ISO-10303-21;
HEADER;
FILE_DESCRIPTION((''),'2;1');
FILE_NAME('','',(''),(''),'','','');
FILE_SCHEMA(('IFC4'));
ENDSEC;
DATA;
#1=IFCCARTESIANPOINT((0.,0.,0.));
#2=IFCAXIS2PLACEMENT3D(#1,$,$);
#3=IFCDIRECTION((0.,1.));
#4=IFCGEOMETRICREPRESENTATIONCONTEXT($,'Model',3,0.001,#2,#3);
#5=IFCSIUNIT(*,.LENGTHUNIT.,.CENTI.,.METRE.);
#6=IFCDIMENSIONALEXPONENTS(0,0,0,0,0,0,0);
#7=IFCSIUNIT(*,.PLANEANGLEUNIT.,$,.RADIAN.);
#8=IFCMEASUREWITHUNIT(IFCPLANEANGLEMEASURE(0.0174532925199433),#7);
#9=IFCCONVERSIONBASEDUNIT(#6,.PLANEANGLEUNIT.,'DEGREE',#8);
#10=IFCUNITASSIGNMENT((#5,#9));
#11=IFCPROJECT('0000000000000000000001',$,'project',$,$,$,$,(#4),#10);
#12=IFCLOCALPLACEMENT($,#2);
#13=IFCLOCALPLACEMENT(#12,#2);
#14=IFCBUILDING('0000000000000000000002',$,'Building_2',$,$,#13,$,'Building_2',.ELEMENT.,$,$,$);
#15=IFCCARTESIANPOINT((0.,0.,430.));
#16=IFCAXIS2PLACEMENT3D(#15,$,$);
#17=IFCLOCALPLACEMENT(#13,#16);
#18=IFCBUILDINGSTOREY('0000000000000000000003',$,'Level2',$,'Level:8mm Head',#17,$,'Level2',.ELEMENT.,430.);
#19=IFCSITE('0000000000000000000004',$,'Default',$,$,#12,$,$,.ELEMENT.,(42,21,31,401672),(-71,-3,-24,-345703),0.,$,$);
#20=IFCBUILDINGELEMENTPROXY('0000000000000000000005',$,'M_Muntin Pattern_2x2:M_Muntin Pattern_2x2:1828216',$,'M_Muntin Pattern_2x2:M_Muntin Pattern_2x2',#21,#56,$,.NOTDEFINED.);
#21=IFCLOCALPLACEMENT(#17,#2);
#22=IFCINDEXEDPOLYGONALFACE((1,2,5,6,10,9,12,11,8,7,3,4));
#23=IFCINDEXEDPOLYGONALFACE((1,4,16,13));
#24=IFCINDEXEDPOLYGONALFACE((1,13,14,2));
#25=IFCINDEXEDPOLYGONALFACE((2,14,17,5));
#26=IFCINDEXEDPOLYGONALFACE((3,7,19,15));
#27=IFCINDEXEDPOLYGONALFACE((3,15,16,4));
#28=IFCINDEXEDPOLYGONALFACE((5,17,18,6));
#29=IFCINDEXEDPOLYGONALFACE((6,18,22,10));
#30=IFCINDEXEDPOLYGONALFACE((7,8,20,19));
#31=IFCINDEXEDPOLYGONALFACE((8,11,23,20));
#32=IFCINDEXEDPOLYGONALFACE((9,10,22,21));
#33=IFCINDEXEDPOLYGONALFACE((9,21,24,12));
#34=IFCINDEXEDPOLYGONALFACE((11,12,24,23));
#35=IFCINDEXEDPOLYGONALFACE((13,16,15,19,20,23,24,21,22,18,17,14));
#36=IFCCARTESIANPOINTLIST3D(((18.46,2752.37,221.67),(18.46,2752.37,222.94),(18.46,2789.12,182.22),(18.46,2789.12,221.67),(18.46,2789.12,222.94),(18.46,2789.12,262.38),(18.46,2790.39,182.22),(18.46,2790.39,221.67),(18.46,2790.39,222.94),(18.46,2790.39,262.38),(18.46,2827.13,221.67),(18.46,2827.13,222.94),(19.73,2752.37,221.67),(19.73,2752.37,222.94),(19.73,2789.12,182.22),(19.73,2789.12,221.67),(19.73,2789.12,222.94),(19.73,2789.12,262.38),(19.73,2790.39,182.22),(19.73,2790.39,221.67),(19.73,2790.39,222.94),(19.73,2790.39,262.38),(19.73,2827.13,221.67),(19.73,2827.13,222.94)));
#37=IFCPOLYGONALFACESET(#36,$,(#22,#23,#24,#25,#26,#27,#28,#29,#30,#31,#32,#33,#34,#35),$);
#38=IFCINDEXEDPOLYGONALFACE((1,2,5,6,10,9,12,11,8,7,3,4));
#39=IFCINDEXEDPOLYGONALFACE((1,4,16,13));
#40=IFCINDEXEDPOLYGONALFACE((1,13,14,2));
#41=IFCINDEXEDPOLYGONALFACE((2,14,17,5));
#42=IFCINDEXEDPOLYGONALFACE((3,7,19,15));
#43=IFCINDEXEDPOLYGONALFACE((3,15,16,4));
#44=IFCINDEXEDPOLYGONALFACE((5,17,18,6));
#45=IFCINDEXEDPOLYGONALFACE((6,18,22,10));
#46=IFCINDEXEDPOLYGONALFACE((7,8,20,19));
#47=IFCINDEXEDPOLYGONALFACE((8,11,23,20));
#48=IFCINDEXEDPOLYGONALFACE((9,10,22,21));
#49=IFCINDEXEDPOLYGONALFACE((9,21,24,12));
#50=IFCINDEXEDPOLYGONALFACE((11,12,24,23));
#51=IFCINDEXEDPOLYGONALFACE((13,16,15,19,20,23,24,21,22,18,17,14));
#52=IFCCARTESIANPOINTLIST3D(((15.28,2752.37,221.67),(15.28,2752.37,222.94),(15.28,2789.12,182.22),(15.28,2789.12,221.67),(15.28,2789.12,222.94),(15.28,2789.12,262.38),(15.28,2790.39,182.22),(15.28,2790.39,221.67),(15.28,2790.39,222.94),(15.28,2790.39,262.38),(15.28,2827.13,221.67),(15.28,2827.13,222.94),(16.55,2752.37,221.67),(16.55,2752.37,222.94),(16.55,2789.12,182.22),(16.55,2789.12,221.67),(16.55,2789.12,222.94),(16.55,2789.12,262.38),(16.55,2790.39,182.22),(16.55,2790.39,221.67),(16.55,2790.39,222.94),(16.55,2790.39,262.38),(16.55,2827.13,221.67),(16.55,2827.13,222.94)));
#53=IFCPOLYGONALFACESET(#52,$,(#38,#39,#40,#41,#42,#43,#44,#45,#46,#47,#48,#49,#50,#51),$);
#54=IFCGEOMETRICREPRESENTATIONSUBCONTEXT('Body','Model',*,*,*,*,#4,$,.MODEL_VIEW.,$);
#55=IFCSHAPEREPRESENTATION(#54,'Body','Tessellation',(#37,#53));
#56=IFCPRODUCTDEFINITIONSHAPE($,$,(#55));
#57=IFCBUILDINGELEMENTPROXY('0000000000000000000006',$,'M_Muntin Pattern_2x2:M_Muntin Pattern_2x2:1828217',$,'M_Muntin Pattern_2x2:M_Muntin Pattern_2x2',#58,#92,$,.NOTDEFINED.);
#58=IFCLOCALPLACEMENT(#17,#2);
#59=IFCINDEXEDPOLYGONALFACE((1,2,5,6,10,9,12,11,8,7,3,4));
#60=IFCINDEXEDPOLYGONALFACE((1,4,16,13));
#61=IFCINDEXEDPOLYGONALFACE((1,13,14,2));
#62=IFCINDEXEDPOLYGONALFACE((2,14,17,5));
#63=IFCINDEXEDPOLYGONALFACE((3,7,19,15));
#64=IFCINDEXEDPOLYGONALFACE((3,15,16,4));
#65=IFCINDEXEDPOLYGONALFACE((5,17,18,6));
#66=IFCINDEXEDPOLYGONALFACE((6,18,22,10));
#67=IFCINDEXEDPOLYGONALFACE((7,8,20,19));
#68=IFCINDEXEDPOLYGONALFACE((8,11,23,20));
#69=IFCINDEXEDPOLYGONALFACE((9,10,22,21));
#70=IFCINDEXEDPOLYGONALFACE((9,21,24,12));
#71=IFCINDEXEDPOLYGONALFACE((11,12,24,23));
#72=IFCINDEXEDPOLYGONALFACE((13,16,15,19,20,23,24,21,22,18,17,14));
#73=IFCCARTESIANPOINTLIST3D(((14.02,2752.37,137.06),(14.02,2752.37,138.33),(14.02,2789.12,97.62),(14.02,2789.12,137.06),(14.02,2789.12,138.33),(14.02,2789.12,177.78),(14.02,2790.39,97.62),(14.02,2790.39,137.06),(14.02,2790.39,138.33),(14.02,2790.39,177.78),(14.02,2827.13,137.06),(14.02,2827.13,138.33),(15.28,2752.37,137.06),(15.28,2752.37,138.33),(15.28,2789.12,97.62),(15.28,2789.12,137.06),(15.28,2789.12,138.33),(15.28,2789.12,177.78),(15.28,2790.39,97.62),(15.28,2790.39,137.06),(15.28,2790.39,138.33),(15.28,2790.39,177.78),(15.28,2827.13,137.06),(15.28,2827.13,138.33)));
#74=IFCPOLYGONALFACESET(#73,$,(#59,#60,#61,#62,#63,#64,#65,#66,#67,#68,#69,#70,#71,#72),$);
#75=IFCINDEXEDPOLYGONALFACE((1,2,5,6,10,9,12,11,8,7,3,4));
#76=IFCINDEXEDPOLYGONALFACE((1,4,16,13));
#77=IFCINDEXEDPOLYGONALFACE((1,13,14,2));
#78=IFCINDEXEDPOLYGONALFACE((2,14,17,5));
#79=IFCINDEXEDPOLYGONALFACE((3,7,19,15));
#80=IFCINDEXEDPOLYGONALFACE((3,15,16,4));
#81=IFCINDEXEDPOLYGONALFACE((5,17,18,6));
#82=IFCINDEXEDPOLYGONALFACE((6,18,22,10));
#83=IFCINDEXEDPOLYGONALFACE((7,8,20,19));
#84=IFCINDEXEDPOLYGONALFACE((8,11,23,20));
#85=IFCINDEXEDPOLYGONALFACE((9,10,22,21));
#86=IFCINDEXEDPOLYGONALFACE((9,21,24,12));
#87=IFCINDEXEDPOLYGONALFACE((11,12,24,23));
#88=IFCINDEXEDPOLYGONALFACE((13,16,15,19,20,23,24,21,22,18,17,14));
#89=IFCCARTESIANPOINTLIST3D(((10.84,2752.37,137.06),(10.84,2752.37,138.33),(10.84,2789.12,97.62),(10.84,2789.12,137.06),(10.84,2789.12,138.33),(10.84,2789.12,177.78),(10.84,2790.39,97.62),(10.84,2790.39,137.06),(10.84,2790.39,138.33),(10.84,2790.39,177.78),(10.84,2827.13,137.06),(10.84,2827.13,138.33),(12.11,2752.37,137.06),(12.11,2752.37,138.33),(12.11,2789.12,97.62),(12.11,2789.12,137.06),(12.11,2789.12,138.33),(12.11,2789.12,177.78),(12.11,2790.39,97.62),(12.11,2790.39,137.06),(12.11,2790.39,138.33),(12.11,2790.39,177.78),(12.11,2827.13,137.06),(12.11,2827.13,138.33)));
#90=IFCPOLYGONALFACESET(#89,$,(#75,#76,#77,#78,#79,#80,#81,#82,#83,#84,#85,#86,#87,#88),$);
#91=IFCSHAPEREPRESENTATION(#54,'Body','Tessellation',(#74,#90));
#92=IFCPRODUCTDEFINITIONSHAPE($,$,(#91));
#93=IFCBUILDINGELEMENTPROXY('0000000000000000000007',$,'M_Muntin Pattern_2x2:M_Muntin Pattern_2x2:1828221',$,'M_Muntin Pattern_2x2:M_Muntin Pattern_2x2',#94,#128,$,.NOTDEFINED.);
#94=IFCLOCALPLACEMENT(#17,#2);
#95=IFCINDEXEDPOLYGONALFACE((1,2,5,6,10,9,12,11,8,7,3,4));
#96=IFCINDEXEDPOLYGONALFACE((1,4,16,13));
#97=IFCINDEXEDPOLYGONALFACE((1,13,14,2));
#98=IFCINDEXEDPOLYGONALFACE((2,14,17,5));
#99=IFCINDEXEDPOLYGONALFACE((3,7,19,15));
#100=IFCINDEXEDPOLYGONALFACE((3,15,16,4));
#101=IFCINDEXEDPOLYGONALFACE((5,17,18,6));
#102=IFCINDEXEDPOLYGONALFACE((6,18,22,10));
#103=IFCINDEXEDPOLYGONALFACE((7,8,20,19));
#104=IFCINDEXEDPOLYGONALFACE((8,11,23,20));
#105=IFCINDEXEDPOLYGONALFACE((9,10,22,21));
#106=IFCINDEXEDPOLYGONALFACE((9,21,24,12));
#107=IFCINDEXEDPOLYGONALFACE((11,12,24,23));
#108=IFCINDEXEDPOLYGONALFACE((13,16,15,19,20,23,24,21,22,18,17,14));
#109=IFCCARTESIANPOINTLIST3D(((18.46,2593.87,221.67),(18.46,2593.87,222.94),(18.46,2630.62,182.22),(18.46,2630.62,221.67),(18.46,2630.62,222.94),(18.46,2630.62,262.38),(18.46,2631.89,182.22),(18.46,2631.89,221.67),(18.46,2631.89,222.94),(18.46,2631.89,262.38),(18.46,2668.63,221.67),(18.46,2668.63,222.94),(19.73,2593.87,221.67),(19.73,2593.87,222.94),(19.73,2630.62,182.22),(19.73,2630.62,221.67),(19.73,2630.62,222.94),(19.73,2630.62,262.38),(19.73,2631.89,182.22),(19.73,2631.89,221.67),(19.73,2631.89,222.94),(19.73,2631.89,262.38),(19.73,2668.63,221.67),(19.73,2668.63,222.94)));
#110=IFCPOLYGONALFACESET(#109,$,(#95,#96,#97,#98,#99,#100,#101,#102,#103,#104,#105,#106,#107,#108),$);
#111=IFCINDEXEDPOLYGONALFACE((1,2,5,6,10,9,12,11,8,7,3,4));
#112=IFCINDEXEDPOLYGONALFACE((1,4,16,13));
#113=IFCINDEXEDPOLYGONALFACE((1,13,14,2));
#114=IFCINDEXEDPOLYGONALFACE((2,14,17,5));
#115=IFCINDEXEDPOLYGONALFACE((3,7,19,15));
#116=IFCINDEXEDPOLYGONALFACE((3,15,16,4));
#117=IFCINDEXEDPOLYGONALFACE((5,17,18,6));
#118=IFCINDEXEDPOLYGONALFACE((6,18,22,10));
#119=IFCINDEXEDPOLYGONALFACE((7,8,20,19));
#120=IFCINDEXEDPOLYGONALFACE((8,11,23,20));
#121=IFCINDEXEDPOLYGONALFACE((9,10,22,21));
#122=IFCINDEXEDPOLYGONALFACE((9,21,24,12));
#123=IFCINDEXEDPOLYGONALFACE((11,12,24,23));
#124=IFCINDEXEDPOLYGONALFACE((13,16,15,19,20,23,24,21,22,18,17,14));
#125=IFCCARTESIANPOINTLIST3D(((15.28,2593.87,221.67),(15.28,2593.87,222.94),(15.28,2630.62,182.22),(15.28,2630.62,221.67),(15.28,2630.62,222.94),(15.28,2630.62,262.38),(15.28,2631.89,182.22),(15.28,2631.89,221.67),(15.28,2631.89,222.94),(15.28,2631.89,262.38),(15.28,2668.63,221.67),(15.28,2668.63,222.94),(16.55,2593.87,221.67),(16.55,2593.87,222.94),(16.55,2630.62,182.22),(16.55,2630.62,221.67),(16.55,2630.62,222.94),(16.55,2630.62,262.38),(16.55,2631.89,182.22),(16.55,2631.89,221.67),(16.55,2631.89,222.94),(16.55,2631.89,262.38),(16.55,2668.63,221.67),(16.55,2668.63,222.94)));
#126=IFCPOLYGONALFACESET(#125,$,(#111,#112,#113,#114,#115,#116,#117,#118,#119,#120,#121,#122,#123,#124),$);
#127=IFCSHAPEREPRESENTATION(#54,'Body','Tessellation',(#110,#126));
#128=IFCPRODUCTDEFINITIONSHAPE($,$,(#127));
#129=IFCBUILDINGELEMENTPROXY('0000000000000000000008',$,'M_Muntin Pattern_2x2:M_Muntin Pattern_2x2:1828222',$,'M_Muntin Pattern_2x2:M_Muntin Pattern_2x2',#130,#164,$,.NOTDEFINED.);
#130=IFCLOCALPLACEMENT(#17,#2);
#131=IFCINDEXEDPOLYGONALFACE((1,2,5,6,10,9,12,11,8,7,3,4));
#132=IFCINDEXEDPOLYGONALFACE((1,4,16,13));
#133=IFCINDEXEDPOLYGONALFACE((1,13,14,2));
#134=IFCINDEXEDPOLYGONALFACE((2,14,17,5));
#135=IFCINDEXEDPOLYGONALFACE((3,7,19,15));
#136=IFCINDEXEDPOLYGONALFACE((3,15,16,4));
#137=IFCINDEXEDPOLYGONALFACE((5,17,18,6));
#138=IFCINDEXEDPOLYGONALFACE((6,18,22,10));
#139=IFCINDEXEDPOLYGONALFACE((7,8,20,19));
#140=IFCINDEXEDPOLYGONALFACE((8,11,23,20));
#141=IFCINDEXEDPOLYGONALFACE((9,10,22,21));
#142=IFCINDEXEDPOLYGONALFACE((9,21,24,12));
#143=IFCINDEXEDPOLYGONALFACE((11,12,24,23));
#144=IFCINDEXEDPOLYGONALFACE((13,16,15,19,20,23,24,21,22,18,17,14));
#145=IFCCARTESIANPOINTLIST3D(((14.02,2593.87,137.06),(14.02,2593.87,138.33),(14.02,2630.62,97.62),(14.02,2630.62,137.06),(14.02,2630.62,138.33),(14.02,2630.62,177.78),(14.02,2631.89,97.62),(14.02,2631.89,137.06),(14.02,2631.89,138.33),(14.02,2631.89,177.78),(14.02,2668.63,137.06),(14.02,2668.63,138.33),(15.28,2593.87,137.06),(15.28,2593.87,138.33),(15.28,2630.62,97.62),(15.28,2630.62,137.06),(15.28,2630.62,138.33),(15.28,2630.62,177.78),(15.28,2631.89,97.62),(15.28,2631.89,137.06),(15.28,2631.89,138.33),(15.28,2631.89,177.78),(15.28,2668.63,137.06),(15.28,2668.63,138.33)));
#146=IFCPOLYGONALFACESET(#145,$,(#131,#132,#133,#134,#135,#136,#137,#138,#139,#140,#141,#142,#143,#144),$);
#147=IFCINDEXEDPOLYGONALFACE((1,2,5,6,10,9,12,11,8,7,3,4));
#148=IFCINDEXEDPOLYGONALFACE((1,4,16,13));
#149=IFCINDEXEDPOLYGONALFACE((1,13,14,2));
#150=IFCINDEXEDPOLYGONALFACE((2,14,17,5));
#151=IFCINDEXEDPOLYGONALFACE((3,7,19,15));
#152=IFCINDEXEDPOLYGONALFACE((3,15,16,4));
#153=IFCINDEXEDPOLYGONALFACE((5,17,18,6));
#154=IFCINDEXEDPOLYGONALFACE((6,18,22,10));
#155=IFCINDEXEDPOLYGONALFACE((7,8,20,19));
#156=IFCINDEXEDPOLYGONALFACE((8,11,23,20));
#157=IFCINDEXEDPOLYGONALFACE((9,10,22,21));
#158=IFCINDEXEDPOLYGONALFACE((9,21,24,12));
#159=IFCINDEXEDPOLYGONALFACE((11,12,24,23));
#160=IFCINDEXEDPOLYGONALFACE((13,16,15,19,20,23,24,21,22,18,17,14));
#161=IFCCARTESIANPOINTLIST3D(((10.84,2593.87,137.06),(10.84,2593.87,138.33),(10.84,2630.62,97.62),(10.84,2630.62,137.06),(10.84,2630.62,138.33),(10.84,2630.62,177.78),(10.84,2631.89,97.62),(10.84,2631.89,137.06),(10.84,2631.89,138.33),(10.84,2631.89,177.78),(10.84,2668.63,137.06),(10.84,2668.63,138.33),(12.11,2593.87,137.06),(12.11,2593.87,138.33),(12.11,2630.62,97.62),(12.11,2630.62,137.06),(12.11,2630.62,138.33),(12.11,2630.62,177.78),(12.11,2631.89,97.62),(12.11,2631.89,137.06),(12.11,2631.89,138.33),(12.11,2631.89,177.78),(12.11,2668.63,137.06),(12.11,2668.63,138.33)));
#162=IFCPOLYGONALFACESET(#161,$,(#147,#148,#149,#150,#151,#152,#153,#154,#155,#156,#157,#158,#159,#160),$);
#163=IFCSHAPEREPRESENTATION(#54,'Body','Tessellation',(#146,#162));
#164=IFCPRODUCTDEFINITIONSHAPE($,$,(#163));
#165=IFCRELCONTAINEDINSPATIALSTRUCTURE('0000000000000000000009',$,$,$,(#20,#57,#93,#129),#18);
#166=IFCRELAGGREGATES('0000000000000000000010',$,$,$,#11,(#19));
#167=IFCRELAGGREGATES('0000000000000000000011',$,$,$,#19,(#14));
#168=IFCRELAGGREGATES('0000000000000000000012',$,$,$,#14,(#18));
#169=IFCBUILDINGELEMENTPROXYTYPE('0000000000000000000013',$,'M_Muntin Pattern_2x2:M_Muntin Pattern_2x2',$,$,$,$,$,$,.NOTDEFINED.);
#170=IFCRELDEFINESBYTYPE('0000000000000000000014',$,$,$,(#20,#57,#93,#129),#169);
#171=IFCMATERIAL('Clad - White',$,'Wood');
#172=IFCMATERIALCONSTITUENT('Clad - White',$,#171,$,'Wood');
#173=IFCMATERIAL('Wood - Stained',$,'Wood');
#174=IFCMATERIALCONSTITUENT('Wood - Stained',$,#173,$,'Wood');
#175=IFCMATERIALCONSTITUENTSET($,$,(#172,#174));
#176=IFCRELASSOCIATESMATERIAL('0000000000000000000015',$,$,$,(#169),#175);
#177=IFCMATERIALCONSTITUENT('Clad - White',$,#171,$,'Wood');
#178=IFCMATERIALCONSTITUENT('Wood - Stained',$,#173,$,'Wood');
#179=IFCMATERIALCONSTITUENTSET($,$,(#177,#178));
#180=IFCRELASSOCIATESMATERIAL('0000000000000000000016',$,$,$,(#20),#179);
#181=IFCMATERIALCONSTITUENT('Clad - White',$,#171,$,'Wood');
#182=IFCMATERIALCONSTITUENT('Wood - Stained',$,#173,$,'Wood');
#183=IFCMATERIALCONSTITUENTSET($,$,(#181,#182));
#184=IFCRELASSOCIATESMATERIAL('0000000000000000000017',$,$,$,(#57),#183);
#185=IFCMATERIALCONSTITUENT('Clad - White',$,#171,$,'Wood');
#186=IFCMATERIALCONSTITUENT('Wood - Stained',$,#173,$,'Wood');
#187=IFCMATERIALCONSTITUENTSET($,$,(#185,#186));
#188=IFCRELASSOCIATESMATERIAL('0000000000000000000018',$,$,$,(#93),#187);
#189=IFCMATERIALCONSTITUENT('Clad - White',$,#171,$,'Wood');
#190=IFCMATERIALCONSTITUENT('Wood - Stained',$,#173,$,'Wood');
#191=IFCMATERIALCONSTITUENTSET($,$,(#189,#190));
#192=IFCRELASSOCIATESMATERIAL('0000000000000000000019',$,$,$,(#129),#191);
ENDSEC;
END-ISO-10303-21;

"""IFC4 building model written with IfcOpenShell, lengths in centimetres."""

from ifc_helpers import new_model, entity, si_unit, converted_unit, direction, frame, origin, place, context, subcontext, project, spatial, indexed_curve, outline, extrude, source, transform, mapped, material, constituent, constituent_set, type_object, type_shapes, element, save


model = new_model("IFC4")

# Units and contexts
model_context = context("Model", 3, precision=0.001, world=origin(), true_north=direction((0.0, 1.0)))
body_context = subcontext(model_context, "Body", "Model", "MODEL_VIEW")
ifc_project = project(units=[si_unit("LENGTHUNIT", "METRE", prefix="CENTI"), converted_unit("PLANEANGLEUNIT", "DEGREE", entity("IfcPlaneAngleMeasure", 0.0174532925199433), si_unit("PLANEANGLEUNIT", "RADIAN"), dimensions=[0, 0, 0, 0, 0, 0, 0])], contexts=[model_context])

# Site, building, storey
site_placement = place(None, origin())
site = spatial("IfcSite", under=ifc_project, at=site_placement, Name="Default", CompositionType="ELEMENT", RefLatitude=(42, 21, 31, 401672), RefLongitude=(-71, -3, -24, -345703), RefElevation=0.0)
building_placement = place(site_placement, origin())
building = spatial("IfcBuilding", under=site, at=building_placement, Name="Building_2", LongName="Building_2", CompositionType="ELEMENT")
storey_placement = place(building_placement, frame((0.0, 0.0, 430.0)))
storey = spatial("IfcBuildingStorey", under=building, at=storey_placement, Name="Level2", ObjectType="Level:8mm Head", LongName="Level2", CompositionType="ELEMENT", Elevation=430.0)

# Shared definitions
ifc_material_1 = material(Name="Wood - Stained", Category="Wood")

# Building element proxies
ifc_material_2 = material(Name="Clad - White", Category="Wood")
ifc_constituent_1 = constituent(ifc_material_2, Name="Clad - White", Category="Wood")
ifc_constituent_2 = constituent(ifc_material_1, Name="Wood - Stained", Category="Wood")
ifc_constituent_set_1 = constituent_set(constituents=[ifc_constituent_1, ifc_constituent_2])
ifc_constituent_3 = constituent(ifc_material_2, Name="Clad - White", Category="Wood")
ifc_constituent_4 = constituent(ifc_material_1, Name="Wood - Stained", Category="Wood")
ifc_constituent_set_2 = constituent_set(constituents=[ifc_constituent_3, ifc_constituent_4])
building_element_proxy_type_1 = type_object("IfcBuildingElementProxyType", Name="M_Muntin Pattern_2x2:M_Muntin Pattern_2x2", PredefinedType="NOTDEFINED", material=ifc_constituent_set_2)
shared_shape_1 = source(origin(), body_context, "Body", "SweptSolid", [
    extrude(outline(indexed_curve([(0.64, -0.64), (40.08, -0.64), (40.08, 0.63), (0.64, 0.63), (0.64, 37.38), (-0.63, 37.38), (-0.63, 0.63), (-40.08, 0.63), (-40.08, -0.64), (-0.63, -0.64), (-0.63, -37.38), (0.64, -37.38), (0.64, -0.64)], self_intersect=False)), frame((0.0, 0.95, 40.08), z_axis=(0.0, 1.0, 0.0), x_axis=(0.0, 0.0, 1.0)), (0.0, 0.0, 1.0), 1.27),
    extrude(outline(indexed_curve([(0.64, -0.64), (40.08, -0.64), (40.08, 0.63), (0.64, 0.63), (0.64, 37.38), (-0.63, 37.38), (-0.63, 0.63), (-40.08, 0.63), (-40.08, -0.64), (-0.63, -0.64), (-0.63, -37.38), (0.64, -37.38), (0.64, -0.64)], self_intersect=False)), frame((0.0, -2.22, 40.08), z_axis=(0.0, 1.0, 0.0), x_axis=(0.0, 0.0, 1.0)), (0.0, 0.0, 1.0), 1.27),
])
type_shapes(building_element_proxy_type_1, [shared_shape_1])
proxy_1_placement = place(storey_placement, frame((17.51, 2789.75, 182.22), z_axis=(0.0, 0.0, 1.0), x_axis=(0.0, -1.0, 0.0)))
element("IfcBuildingElementProxy", 1, at=proxy_1_placement, inside=storey, type_object=building_element_proxy_type_1, material=ifc_constituent_set_1, Name="M_Muntin Pattern_2x2:M_Muntin Pattern_2x2:1828216", ObjectType="M_Muntin Pattern_2x2:M_Muntin Pattern_2x2", PredefinedType="NOTDEFINED", context=body_context, shape_type="MappedRepresentation", body=[
    mapped(shared_shape_1, transform((0.0, 0.0, 0.0), scale=1.0)),
])
ifc_constituent_5 = constituent(ifc_material_2, Name="Clad - White", Category="Wood")
ifc_constituent_6 = constituent(ifc_material_1, Name="Wood - Stained", Category="Wood")
ifc_constituent_set_3 = constituent_set(constituents=[ifc_constituent_5, ifc_constituent_6])
proxy_2_placement = place(storey_placement, frame((13.06, 2789.75, 97.62), z_axis=(0.0, 0.0, 1.0), x_axis=(0.0, -1.0, 0.0)))
element("IfcBuildingElementProxy", 2, at=proxy_2_placement, inside=storey, type_object=building_element_proxy_type_1, material=ifc_constituent_set_3, Name="M_Muntin Pattern_2x2:M_Muntin Pattern_2x2:1828217", ObjectType="M_Muntin Pattern_2x2:M_Muntin Pattern_2x2", PredefinedType="NOTDEFINED", context=body_context, shape_type="MappedRepresentation", body=[
    mapped(shared_shape_1, transform((0.0, 0.0, 0.0), scale=1.0)),
])
ifc_constituent_7 = constituent(ifc_material_2, Name="Clad - White", Category="Wood")
ifc_constituent_8 = constituent(ifc_material_1, Name="Wood - Stained", Category="Wood")
ifc_constituent_set_4 = constituent_set(constituents=[ifc_constituent_7, ifc_constituent_8])
proxy_3_placement = place(storey_placement, frame((17.51, 2631.25, 182.22), z_axis=(0.0, 0.0, 1.0), x_axis=(0.0, -1.0, 0.0)))
element("IfcBuildingElementProxy", 3, at=proxy_3_placement, inside=storey, type_object=building_element_proxy_type_1, material=ifc_constituent_set_4, Name="M_Muntin Pattern_2x2:M_Muntin Pattern_2x2:1828221", ObjectType="M_Muntin Pattern_2x2:M_Muntin Pattern_2x2", PredefinedType="NOTDEFINED", context=body_context, shape_type="MappedRepresentation", body=[
    mapped(shared_shape_1, transform((0.0, 0.0, 0.0), scale=1.0)),
])
ifc_constituent_9 = constituent(ifc_material_2, Name="Clad - White", Category="Wood")
ifc_constituent_10 = constituent(ifc_material_1, Name="Wood - Stained", Category="Wood")
ifc_constituent_set_5 = constituent_set(constituents=[ifc_constituent_9, ifc_constituent_10])
proxy_4_placement = place(storey_placement, frame((13.06, 2631.25, 97.62), z_axis=(0.0, 0.0, 1.0), x_axis=(0.0, -1.0, 0.0)))
element("IfcBuildingElementProxy", 4, at=proxy_4_placement, inside=storey, type_object=building_element_proxy_type_1, material=ifc_constituent_set_5, Name="M_Muntin Pattern_2x2:M_Muntin Pattern_2x2:1828222", ObjectType="M_Muntin Pattern_2x2:M_Muntin Pattern_2x2", PredefinedType="NOTDEFINED", context=body_context, shape_type="MappedRepresentation", body=[
    mapped(shared_shape_1, transform((0.0, 0.0, 0.0), scale=1.0)),
])

save(model, "model.ifc")
